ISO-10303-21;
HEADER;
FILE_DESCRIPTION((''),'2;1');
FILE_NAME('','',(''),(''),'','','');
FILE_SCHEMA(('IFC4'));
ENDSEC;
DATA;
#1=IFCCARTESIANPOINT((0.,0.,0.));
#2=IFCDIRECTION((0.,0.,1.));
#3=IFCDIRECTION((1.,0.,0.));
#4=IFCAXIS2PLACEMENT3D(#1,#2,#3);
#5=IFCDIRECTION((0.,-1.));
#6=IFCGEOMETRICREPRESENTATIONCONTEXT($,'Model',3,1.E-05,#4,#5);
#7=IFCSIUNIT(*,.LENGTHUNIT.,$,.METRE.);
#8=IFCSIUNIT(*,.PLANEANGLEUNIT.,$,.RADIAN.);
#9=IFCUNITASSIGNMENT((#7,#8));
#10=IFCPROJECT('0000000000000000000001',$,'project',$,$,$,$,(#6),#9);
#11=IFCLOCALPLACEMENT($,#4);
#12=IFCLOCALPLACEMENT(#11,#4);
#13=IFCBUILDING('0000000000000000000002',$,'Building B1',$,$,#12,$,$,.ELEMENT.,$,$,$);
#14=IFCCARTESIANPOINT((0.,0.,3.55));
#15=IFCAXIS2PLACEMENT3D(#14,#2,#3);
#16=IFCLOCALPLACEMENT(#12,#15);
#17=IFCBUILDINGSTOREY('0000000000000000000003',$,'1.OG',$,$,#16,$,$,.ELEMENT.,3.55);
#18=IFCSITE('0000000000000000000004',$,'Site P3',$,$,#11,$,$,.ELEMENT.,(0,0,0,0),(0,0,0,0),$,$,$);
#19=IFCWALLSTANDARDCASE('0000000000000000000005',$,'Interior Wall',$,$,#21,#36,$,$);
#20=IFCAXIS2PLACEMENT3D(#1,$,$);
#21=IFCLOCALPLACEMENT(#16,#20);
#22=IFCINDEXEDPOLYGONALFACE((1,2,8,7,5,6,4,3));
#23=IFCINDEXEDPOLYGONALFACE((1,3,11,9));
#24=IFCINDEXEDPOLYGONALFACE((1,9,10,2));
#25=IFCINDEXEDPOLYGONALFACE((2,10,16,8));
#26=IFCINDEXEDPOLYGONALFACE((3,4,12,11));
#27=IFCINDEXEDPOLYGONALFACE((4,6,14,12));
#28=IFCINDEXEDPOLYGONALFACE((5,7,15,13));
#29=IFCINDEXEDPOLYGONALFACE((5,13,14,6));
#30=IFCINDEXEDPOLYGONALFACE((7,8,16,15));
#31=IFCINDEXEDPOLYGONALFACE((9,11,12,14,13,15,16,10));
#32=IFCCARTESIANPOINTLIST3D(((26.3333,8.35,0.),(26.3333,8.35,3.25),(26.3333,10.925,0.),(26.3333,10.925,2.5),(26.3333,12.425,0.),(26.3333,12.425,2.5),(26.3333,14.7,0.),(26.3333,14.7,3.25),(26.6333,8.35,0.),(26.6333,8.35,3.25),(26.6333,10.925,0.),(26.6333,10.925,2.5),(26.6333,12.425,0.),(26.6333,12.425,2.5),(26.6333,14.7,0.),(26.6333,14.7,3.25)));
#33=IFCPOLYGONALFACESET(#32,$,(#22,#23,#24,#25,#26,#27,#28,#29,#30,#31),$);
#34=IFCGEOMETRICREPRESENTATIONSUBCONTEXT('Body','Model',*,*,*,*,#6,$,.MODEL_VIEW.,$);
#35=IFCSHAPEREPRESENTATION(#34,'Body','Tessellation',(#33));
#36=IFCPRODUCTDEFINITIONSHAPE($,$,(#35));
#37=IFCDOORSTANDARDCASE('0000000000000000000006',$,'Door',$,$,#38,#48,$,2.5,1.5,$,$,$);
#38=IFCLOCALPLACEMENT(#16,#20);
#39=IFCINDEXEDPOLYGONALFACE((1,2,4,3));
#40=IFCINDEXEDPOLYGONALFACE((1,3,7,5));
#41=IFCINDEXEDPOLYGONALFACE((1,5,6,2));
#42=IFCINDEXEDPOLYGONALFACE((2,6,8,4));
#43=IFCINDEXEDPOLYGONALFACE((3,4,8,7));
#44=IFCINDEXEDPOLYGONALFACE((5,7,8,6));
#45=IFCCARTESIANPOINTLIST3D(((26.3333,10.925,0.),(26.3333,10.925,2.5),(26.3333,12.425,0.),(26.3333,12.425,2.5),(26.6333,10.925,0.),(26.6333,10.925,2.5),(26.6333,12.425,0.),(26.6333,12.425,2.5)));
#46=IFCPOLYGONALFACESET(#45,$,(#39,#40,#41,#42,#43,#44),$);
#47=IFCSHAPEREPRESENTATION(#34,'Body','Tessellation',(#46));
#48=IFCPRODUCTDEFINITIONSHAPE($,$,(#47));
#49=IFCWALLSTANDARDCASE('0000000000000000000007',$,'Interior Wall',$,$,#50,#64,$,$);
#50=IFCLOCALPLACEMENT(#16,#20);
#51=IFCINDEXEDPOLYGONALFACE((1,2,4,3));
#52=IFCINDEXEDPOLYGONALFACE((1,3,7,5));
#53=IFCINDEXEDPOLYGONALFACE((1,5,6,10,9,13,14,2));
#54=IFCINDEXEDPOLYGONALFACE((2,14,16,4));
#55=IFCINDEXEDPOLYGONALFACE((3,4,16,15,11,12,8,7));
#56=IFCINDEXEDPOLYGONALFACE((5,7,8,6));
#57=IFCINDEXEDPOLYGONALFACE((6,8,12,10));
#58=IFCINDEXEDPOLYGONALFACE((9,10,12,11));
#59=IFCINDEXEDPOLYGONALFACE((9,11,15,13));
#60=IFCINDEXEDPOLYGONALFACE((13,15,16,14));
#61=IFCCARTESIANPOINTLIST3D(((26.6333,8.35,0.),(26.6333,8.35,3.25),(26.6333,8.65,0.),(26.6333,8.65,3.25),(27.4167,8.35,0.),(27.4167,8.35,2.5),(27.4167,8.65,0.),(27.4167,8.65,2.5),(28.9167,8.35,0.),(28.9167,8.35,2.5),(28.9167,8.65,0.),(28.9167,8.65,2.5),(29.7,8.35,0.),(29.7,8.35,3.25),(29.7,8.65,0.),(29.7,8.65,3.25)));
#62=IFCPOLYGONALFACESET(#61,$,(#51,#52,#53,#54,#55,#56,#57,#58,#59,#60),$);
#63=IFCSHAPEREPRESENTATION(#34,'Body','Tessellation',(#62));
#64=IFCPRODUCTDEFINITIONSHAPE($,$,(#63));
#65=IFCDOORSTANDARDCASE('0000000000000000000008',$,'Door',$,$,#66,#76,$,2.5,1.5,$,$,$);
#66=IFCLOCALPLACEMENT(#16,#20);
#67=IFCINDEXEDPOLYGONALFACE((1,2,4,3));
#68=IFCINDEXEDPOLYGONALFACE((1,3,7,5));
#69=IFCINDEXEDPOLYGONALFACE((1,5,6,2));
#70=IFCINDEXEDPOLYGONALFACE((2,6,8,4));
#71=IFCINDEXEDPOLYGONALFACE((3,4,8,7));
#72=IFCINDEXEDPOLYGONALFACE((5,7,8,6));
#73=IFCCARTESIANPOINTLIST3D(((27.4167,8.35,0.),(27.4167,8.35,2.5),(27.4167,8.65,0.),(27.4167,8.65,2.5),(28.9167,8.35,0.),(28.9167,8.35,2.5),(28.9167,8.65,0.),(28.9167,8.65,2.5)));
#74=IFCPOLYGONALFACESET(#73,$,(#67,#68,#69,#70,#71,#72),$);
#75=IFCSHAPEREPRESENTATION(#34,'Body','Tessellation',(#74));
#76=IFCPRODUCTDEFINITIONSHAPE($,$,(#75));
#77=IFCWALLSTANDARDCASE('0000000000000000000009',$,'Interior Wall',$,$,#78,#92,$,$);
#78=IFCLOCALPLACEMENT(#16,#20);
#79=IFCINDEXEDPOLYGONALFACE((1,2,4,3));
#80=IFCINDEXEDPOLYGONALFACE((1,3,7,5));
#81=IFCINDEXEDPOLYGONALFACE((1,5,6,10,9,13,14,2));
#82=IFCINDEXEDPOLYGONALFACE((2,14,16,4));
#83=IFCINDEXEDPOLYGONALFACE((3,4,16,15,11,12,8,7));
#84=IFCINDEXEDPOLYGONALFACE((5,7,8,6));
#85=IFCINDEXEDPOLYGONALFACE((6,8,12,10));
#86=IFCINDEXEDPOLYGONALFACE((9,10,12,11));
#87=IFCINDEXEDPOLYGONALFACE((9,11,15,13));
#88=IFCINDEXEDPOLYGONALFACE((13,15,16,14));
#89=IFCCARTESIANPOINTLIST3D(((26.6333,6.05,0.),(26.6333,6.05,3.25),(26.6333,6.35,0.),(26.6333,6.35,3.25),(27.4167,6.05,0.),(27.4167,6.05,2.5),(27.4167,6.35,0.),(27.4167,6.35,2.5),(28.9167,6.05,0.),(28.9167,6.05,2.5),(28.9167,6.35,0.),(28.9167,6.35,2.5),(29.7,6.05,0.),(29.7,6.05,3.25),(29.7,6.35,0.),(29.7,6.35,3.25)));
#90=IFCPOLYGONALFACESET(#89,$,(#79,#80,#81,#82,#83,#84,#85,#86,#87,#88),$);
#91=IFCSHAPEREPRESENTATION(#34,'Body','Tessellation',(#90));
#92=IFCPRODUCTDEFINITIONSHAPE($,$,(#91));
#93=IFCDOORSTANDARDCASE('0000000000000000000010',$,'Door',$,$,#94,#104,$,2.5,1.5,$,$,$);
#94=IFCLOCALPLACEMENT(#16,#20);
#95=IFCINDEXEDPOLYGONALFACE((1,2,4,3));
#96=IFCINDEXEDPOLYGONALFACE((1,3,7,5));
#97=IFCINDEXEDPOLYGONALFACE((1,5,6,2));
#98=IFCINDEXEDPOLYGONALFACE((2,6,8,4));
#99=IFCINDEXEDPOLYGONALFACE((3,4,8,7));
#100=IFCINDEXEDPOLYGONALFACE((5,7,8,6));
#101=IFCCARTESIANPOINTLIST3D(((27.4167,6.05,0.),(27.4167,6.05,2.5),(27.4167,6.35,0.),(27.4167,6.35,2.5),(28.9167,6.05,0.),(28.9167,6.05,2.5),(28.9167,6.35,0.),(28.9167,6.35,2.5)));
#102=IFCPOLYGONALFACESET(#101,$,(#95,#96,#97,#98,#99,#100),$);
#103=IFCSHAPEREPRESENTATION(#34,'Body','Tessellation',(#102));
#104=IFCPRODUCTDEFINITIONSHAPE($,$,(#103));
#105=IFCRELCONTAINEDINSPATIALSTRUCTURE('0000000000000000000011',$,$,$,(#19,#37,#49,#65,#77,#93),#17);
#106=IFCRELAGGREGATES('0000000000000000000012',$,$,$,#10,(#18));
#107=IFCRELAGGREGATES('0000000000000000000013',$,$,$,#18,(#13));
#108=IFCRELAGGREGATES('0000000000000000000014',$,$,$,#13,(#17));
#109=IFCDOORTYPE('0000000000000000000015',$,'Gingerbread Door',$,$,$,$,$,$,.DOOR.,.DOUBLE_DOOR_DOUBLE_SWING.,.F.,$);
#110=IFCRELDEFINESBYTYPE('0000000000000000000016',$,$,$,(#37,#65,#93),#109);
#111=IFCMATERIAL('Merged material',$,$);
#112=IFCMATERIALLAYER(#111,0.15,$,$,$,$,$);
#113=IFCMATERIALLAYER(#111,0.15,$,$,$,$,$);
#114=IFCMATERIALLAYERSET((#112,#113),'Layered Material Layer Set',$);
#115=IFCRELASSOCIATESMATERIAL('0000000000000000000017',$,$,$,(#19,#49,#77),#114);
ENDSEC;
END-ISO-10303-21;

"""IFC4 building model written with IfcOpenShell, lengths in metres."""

from ifc_helpers import new_model, si_unit, direction, frame, origin_with_axes, place, context, subcontext, project, spatial, polyline, outline, extrude, source, transform, mapped, material, layer, layer_set, layer_usage, type_object, element, fill, save


model = new_model("IFC4")

# Units and contexts
model_context = context("Model", 3, precision=1e-05, world=origin_with_axes(), true_north=direction((0.0, -1.0)))
body_context = subcontext(model_context, "Body", "Model", "MODEL_VIEW")
ifc_project = project(units=[si_unit("LENGTHUNIT", "METRE"), si_unit("PLANEANGLEUNIT", "RADIAN")], contexts=[model_context])

# Site, building, storey
site_placement = place(None, origin_with_axes())
site = spatial("IfcSite", under=ifc_project, at=site_placement, Name="Site P3", CompositionType="ELEMENT", RefLatitude=(0, 0, 0, 0), RefLongitude=(0, 0, 0, 0))
building_placement = place(site_placement, origin_with_axes())
building = spatial("IfcBuilding", under=site, at=building_placement, Name="Building B1", CompositionType="ELEMENT")
storey_placement = place(building_placement, frame((0.0, 0.0, 3.55), z_axis=(0.0, 0.0, 1.0), x_axis=(1.0, 0.0, 0.0)))
storey = spatial("IfcBuildingStorey", under=building, at=storey_placement, Name="1.OG", CompositionType="ELEMENT", Elevation=3.55)

# Shared definitions
ifc_material = material(Name="Merged material")

# Shared definitions
ifc_layer_1 = layer(ifc_material, 0.15)
ifc_layer_2 = layer(ifc_material, 0.15)
ifc_layer_set_1 = layer_set([ifc_layer_1, ifc_layer_2], Name="Layered Material Layer Set")
ifc_layer_usage_1 = layer_usage(ifc_layer_set_1, "AXIS2", "POSITIVE", -0.15)
door_type = type_object("IfcDoorType", Name="Gingerbread Door", OperationType="DOUBLE_DOOR_DOUBLE_SWING", ParameterTakesPrecedence=False, PredefinedType="DOOR")
shared_shape_1 = source(origin_with_axes(), body_context, "Body", "SweptSolid", [
    extrude(outline(polyline([(0.0, 0.0), (0.0, 1.5), (2.5, 1.5), (2.5, 0.0), (0.0, 0.0)])), frame((0.0, -0.15, 0.0), z_axis=(0.0, 1.0, 0.0), x_axis=(0.0, 0.0, 1.0)), (0.0, 0.0, 1.0), 0.3),
])

# Walls, openings, doors
wall_1_placement = place(storey_placement, frame((26.4833, 14.7, 0.0), z_axis=(0.0, 0.0, 1.0), x_axis=(0.0, -1.0, 0.0)))
wall_1 = element("IfcWallStandardCase", 1, at=wall_1_placement, inside=storey, material=ifc_layer_usage_1, Name="Interior Wall", context=body_context, shape_type="SweptSolid", body=[
    extrude(outline(polyline([(0.0, 0.15), (6.35, 0.15), (6.35, -0.15), (0.0, -0.15), (0.0, 0.15)])), origin_with_axes(), (0.0, 0.0, 1.0), 3.25),
])
opening_1_placement = place(wall_1_placement, frame((2.275, 0.0, 0.0), z_axis=(0.0, 0.0, 1.0), x_axis=(1.0, 0.0, 0.0)))
opening_1 = element("IfcOpeningStandardCase", 2, at=opening_1_placement, cuts=wall_1, context=body_context, shape_type="SweptSolid", body=[
    extrude(outline(polyline([(0.0, 0.0), (0.0, 1.5), (2.5, 1.5), (2.5, 0.0), (0.0, 0.0)])), frame((0.0, -0.15, 0.0), z_axis=(0.0, 1.0, 0.0), x_axis=(0.0, 0.0, 1.0)), (0.0, 0.0, 1.0), 0.3),
])
door_1_placement = place(opening_1_placement, origin_with_axes())
door_1 = element("IfcDoorStandardCase", 3, at=door_1_placement, inside=storey, type_object=door_type, Name="Door", OverallHeight=2.5, OverallWidth=1.5, context=body_context, shape_type="MappedRepresentation", body=[
    mapped(shared_shape_1, transform((0.0, 0.0, 0.0))),
])
fill(opening_1, door_1)
wall_2_placement = place(storey_placement, frame((26.6333, 8.5, 0.0), z_axis=(0.0, 0.0, 1.0), x_axis=(1.0, 0.0, 0.0)))
wall_2 = element("IfcWallStandardCase", 4, at=wall_2_placement, inside=storey, material=ifc_layer_usage_1, Name="Interior Wall", context=body_context, shape_type="SweptSolid", body=[
    extrude(outline(polyline([(0.0, 0.15), (3.0667, 0.15), (3.0667, -0.15), (0.0, -0.15), (0.0, 0.15)])), origin_with_axes(), (0.0, 0.0, 1.0), 3.25),
])
opening_2_placement = place(wall_2_placement, frame((0.7833, 0.0, 0.0), z_axis=(0.0, 0.0, 1.0), x_axis=(1.0, 0.0, 0.0)))
opening_2 = element("IfcOpeningStandardCase", 5, at=opening_2_placement, cuts=wall_2, context=body_context, shape_type="SweptSolid", body=[
    extrude(outline(polyline([(0.0, 0.0), (0.0, 1.5), (2.5, 1.5), (2.5, 0.0), (0.0, 0.0)])), frame((0.0, -0.15, 0.0), z_axis=(0.0, 1.0, 0.0), x_axis=(0.0, 0.0, 1.0)), (0.0, 0.0, 1.0), 0.3),
])
door_2_placement = place(opening_2_placement, origin_with_axes())
door_2 = element("IfcDoorStandardCase", 6, at=door_2_placement, inside=storey, type_object=door_type, Name="Door", OverallHeight=2.5, OverallWidth=1.5, context=body_context, shape_type="MappedRepresentation", body=[
    mapped(shared_shape_1, transform((0.0, 0.0, 0.0))),
])
fill(opening_2, door_2)
wall_3_placement = place(storey_placement, frame((26.6333, 6.2, 0.0), z_axis=(0.0, 0.0, 1.0), x_axis=(1.0, 0.0, 0.0)))
wall_3 = element("IfcWallStandardCase", 7, at=wall_3_placement, inside=storey, material=ifc_layer_usage_1, Name="Interior Wall", context=body_context, shape_type="SweptSolid", body=[
    extrude(outline(polyline([(0.0, 0.15), (3.0667, 0.15), (3.0667, -0.15), (0.0, -0.15), (0.0, 0.15)])), origin_with_axes(), (0.0, 0.0, 1.0), 3.25),
])
opening_3_placement = place(wall_3_placement, frame((0.7833, 0.0, 0.0), z_axis=(0.0, 0.0, 1.0), x_axis=(1.0, 0.0, 0.0)))
opening_3 = element("IfcOpeningStandardCase", 8, at=opening_3_placement, cuts=wall_3, context=body_context, shape_type="SweptSolid", body=[
    extrude(outline(polyline([(0.0, 0.0), (0.0, 1.5), (2.5, 1.5), (2.5, 0.0), (0.0, 0.0)])), frame((0.0, -0.15, 0.0), z_axis=(0.0, 1.0, 0.0), x_axis=(0.0, 0.0, 1.0)), (0.0, 0.0, 1.0), 0.3),
])
door_3_placement = place(opening_3_placement, origin_with_axes())
door_3 = element("IfcDoorStandardCase", 9, at=door_3_placement, inside=storey, type_object=door_type, Name="Door", OverallHeight=2.5, OverallWidth=1.5, context=body_context, shape_type="MappedRepresentation", body=[
    mapped(shared_shape_1, transform((0.0, 0.0, 0.0))),
])
fill(opening_3, door_3)

save(model, "model.ifc")
